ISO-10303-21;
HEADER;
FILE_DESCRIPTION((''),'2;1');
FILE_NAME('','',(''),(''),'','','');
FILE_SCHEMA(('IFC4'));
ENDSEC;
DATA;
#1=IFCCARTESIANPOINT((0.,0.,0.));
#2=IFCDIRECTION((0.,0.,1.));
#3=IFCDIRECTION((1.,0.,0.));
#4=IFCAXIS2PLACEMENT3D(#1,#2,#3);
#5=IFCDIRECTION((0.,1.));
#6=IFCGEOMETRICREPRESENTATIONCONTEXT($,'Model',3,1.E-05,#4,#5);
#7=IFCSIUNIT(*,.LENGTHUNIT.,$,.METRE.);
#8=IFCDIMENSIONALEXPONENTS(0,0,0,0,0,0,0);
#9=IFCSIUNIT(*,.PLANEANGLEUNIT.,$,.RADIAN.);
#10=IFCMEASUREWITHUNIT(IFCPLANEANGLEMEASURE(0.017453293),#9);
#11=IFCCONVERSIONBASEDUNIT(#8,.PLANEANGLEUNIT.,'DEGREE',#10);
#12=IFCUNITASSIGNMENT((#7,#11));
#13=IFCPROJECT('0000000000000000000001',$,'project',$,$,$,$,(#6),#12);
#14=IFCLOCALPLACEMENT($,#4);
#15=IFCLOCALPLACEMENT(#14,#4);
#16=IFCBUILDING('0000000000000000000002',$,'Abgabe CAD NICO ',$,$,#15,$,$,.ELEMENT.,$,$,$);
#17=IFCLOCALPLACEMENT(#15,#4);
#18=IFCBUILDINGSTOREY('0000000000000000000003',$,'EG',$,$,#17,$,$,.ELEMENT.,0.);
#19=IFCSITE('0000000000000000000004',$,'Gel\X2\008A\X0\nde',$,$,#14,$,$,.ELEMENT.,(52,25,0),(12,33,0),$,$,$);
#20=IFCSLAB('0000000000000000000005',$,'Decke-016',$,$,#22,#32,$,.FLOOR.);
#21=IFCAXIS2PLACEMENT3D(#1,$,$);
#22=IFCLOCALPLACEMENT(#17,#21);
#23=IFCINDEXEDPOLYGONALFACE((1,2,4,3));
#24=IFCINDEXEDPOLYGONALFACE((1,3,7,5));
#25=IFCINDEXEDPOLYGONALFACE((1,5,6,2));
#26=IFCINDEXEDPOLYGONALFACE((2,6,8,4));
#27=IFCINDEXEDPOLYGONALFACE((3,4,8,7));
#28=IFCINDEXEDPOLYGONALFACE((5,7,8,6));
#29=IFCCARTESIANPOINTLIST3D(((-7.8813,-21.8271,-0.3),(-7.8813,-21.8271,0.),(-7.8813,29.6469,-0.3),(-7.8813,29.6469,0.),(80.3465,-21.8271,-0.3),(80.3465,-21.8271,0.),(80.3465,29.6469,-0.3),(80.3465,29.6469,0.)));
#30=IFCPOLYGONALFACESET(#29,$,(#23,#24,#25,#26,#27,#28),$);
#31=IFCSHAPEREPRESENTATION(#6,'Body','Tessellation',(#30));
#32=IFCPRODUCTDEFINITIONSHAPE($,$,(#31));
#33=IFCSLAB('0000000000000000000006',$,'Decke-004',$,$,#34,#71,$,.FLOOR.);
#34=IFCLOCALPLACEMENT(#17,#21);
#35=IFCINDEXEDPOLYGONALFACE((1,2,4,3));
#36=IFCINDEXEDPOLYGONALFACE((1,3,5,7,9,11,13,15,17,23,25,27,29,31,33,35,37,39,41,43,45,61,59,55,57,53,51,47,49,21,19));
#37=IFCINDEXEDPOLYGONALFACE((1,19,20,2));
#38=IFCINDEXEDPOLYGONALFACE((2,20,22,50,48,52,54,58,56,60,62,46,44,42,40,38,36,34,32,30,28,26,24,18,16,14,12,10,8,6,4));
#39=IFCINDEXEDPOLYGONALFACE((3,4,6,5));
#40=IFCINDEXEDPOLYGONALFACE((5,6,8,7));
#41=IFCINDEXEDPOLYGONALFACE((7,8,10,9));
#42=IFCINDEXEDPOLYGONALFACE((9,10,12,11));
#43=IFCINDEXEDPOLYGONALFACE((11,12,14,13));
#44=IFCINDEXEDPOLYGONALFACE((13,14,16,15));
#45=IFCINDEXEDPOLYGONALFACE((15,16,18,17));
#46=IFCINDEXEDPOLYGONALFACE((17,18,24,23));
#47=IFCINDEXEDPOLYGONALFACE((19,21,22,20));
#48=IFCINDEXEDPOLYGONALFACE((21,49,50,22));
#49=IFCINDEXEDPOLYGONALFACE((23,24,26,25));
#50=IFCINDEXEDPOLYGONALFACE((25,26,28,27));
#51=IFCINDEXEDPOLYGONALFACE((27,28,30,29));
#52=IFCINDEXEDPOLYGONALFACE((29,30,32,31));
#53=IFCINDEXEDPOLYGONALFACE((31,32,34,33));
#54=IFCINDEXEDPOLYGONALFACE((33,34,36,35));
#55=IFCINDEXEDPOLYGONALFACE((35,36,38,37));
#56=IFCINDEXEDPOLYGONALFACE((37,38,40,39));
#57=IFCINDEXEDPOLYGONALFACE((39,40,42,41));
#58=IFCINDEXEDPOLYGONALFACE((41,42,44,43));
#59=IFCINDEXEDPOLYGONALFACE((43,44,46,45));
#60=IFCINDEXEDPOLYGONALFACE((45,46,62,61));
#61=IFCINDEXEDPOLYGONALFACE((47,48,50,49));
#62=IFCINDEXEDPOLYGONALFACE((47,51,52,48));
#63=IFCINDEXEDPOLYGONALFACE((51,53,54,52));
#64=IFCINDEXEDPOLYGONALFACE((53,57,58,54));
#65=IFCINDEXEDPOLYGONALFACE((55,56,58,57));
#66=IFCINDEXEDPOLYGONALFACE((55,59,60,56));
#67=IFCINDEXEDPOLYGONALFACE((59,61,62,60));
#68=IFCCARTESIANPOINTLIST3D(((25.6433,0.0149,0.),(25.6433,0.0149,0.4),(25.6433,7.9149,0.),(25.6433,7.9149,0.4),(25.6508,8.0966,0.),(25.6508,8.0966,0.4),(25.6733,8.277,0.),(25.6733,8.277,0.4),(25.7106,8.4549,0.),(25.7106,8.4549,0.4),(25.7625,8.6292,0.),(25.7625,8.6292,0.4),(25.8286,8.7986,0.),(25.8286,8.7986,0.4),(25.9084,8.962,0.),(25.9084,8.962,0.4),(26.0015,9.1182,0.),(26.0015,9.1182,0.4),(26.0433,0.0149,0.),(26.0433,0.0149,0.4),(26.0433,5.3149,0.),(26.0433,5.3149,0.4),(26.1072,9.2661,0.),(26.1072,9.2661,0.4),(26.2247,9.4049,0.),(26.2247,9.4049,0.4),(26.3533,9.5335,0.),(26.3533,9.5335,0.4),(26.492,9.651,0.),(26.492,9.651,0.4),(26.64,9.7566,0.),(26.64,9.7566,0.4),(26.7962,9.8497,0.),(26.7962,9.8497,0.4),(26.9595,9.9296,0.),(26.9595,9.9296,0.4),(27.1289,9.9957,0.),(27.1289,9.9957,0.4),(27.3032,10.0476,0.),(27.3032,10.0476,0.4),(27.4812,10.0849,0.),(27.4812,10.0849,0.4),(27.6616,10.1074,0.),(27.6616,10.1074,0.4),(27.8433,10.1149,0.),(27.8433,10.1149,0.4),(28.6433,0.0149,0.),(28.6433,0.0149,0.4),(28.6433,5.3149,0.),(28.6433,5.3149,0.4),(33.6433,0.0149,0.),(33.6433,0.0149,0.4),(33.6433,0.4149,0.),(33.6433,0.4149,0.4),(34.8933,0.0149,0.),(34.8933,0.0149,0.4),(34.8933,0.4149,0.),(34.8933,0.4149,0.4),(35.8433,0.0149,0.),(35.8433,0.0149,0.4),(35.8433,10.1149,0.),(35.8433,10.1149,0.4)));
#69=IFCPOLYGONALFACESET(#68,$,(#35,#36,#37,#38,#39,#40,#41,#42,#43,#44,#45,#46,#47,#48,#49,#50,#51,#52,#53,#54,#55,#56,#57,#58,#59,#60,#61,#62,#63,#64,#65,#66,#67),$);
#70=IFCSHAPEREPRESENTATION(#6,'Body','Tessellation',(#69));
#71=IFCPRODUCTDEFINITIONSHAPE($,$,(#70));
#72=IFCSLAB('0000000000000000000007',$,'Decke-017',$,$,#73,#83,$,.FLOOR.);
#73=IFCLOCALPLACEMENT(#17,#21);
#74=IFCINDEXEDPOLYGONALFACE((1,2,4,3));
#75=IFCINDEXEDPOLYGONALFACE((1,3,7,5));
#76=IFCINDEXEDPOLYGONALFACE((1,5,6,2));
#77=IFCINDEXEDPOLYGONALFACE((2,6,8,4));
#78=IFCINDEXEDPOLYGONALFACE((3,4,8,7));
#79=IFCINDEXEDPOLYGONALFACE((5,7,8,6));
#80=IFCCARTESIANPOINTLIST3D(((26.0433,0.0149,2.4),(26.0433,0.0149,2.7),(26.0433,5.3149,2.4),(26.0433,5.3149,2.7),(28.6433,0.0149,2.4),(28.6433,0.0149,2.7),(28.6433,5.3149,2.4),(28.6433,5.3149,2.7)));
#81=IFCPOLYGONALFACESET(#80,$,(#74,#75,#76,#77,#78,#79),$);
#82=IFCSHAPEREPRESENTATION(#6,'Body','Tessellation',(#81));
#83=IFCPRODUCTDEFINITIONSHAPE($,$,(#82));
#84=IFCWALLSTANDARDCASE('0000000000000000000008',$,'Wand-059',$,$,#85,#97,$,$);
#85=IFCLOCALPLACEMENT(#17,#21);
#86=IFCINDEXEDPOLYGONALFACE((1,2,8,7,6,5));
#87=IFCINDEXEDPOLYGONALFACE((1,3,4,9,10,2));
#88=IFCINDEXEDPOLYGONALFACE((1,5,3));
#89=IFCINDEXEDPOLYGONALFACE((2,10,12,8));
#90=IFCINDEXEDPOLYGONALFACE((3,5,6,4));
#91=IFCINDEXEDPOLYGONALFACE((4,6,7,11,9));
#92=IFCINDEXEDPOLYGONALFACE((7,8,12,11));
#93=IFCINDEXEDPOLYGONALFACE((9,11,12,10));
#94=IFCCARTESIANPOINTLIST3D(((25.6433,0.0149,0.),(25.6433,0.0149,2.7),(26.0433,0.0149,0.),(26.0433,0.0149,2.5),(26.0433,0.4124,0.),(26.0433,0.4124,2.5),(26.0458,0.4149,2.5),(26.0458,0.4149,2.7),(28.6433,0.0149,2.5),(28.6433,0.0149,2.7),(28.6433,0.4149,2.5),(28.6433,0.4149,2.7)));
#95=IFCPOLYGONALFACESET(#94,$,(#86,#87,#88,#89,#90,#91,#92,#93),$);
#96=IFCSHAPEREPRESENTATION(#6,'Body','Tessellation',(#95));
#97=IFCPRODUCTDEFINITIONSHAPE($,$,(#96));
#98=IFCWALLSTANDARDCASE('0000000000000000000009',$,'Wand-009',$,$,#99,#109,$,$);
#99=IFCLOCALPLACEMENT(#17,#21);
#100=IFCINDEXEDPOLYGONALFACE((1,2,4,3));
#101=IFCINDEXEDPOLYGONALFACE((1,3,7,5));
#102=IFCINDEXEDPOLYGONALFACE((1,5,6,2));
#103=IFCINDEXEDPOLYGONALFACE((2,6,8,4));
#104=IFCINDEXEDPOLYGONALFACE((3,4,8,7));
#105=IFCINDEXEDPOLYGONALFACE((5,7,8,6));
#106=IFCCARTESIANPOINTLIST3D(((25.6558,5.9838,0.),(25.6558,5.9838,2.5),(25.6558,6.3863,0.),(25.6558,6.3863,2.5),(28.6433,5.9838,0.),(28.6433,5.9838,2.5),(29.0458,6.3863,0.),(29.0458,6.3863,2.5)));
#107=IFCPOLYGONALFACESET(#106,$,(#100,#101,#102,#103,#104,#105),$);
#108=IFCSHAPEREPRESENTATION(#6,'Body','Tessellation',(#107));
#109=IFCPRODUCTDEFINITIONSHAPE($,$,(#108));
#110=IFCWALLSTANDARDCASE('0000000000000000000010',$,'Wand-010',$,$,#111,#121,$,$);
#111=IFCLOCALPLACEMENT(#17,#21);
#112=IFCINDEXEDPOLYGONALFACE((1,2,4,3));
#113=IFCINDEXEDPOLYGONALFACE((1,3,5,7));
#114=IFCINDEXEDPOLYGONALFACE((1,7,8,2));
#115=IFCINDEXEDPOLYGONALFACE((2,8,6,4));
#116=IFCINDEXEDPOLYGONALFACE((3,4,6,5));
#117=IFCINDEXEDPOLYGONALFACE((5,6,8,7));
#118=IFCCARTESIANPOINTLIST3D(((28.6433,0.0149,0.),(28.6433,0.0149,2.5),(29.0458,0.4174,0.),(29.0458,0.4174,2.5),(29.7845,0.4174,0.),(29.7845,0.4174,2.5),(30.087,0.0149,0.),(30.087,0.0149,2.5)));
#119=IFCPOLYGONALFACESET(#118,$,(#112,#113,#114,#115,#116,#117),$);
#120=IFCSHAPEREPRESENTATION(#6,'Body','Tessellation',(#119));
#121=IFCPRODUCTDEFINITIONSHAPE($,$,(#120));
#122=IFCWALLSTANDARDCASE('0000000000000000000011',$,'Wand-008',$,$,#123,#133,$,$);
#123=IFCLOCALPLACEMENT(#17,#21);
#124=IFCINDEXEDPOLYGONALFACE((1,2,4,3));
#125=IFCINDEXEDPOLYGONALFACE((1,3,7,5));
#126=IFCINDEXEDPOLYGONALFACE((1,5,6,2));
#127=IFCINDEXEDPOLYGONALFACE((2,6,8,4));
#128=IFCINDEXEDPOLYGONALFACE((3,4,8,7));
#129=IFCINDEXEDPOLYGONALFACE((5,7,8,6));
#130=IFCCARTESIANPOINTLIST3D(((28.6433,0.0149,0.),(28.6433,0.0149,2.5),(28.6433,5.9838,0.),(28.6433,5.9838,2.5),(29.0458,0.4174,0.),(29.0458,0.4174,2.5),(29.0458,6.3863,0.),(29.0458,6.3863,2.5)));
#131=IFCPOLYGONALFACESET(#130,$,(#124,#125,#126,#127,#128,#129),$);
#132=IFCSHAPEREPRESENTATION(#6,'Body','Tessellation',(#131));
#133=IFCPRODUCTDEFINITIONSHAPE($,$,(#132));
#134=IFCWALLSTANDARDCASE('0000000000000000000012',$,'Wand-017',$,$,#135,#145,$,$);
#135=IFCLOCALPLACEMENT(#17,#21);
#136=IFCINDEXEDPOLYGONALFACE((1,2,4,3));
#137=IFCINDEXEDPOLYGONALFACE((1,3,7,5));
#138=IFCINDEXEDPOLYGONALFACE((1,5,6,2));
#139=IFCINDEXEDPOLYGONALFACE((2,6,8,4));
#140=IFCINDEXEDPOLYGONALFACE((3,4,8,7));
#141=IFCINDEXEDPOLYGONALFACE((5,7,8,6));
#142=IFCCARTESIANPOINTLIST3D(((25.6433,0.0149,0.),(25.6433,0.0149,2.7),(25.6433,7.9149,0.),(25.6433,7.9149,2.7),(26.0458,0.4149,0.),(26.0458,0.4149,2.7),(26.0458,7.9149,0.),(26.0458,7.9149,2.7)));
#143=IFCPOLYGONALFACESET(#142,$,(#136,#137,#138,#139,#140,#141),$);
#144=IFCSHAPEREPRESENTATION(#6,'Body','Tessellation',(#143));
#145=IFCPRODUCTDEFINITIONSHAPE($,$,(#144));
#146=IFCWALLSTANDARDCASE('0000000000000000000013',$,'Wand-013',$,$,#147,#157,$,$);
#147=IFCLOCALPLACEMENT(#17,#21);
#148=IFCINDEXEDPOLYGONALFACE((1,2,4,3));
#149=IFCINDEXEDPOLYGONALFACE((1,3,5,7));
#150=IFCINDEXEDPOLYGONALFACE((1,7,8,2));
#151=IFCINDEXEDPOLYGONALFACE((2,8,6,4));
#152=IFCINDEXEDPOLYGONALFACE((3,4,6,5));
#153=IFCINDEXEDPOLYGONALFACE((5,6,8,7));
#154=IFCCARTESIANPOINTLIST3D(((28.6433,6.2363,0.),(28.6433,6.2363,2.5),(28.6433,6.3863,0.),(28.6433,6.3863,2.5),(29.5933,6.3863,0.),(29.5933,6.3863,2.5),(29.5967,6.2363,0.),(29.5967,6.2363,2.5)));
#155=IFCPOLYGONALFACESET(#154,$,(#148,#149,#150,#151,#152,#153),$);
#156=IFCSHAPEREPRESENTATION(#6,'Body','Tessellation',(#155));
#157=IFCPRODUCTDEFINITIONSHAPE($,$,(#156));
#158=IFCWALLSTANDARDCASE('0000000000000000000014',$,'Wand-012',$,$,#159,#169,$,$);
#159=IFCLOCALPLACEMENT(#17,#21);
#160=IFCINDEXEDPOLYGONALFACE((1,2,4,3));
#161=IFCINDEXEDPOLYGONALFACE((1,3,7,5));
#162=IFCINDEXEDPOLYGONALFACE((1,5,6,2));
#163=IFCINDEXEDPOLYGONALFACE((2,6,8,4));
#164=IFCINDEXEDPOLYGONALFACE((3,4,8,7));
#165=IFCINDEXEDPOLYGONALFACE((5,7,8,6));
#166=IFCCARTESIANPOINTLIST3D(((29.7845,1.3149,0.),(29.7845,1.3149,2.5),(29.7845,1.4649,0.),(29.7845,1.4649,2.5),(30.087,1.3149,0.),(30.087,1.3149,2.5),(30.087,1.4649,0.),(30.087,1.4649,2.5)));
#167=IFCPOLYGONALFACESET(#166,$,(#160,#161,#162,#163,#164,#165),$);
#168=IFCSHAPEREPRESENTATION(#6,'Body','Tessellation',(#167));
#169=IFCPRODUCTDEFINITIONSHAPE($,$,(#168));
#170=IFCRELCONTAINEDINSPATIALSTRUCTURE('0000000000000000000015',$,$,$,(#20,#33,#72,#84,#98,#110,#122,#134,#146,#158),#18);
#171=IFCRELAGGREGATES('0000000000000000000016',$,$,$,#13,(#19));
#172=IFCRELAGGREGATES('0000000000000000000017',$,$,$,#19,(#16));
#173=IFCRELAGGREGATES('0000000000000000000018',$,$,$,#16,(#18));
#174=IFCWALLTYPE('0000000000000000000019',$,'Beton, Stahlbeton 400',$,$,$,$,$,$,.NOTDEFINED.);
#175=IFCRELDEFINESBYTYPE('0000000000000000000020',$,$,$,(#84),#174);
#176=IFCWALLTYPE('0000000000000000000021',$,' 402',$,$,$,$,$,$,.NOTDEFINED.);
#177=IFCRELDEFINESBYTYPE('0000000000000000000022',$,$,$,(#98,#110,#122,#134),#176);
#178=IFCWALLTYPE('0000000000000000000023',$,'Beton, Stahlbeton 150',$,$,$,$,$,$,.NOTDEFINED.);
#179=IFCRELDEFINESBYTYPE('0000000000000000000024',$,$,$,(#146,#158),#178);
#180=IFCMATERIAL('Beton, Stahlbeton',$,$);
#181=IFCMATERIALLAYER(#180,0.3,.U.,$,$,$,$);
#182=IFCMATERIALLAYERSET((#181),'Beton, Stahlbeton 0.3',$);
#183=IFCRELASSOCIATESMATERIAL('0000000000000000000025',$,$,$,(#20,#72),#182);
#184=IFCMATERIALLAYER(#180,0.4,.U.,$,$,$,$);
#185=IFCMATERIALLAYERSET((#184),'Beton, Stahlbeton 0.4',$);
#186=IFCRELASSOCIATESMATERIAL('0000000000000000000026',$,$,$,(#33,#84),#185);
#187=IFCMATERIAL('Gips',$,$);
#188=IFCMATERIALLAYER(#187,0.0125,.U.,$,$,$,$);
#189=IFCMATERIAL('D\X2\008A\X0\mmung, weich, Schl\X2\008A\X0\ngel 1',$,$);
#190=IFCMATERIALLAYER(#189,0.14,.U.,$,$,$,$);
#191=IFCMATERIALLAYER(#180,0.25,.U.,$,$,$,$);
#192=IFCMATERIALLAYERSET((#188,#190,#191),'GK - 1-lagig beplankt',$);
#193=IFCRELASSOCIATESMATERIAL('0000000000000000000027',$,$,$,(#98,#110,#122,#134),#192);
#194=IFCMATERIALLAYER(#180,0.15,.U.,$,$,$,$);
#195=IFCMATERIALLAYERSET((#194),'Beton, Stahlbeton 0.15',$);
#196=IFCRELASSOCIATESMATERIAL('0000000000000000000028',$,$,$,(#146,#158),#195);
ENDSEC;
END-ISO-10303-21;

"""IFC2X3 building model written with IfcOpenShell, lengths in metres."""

from ifc_helpers import new_model, entity, si_unit, converted_unit, point, direction, frame, frame_2d, origin_with_axes, origin_2d_with_axis, place, context, project, spatial, polyline, circle_curve, parameter, trimmed, segment, composite_curve, rectangle, outline, extrude, material, layer, layer_set, layer_usage, type_object, element, save


model = new_model("IFC2X3")

# Units and contexts
model_context = context("Model", 3, precision=1e-05, world=origin_with_axes(), true_north=direction((0.0, 1.0)))
ifc_project = project(units=[si_unit("LENGTHUNIT", "METRE"), converted_unit("PLANEANGLEUNIT", "DEGREE", entity("IfcPlaneAngleMeasure", 0.017453293), si_unit("PLANEANGLEUNIT", "RADIAN"), dimensions=[0, 0, 0, 0, 0, 0, 0])], contexts=[model_context])

# Site, building, storey
site_placement = place(None, origin_with_axes())
site = spatial("IfcSite", under=ifc_project, at=site_placement, Name="Gel\u008ande", CompositionType="ELEMENT", RefLatitude=(52, 25, 0), RefLongitude=(12, 33, 0))
building_placement = place(site_placement, origin_with_axes())
building = spatial("IfcBuilding", under=site, at=building_placement, Name="Abgabe CAD NICO ", CompositionType="ELEMENT")
storey_placement = place(building_placement, origin_with_axes())
storey = spatial("IfcBuildingStorey", under=building, at=storey_placement, Name="EG", CompositionType="ELEMENT", Elevation=0.0)

# Slab
ifc_material_1 = material(Name="Beton, Stahlbeton")
ifc_layer_1 = layer(ifc_material_1, 0.3, ventilated="UNKNOWN")
ifc_layer_set_1 = layer_set([ifc_layer_1], Name="Beton, Stahlbeton 0.3")
ifc_layer_usage_1 = layer_usage(ifc_layer_set_1, "AXIS3", "NEGATIVE", 0.3)
slab_1_placement = place(storey_placement, frame((-7.8813, 29.6469, -0.3), z_axis=(0.0, 0.0, 1.0), x_axis=(1.0, 0.0, 0.0)))
element("IfcSlab", 1, at=slab_1_placement, inside=storey, material=ifc_layer_usage_1, Name="Decke-016", PredefinedType="FLOOR", context=model_context, shape_type="SweptSolid", body=[
    extrude(outline(polyline([(0.0, 0.0), (0.0, -51.474), (88.2278, -51.474), (88.2278, 0.0), (0.0, 0.0)])), origin_with_axes(), (0.0, 0.0, 1.0), 0.3),
])

# Slabs
ifc_layer_2 = layer(ifc_material_1, 0.4, ventilated="UNKNOWN")
ifc_layer_set_2 = layer_set([ifc_layer_2], Name="Beton, Stahlbeton 0.4")
ifc_layer_usage_2 = layer_usage(ifc_layer_set_2, "AXIS3", "NEGATIVE", 0.4)
slab_2_placement = place(storey_placement, frame((27.8433, 10.1149, 0.0), z_axis=(0.0, 0.0, 1.0), x_axis=(1.0, 0.0, 0.0)))
element("IfcSlab", 2, at=slab_2_placement, inside=storey, material=ifc_layer_usage_2, Name="Decke-004", PredefinedType="FLOOR", context=model_context, shape_type="SweptSolid", body=[
    extrude(outline(composite_curve([segment(polyline([(-2.2, -2.2), (-2.2, -10.1), (-1.8, -10.1), (-1.8, -4.8), (0.8, -4.8), (0.8, -10.1), (5.8, -10.1), (5.8, -9.7), (7.05, -9.7), (7.05, -10.1), (8.0, -10.1), (8.0, 0.0), (0.0, 0.0)]), True, "CONTINUOUS"), segment(trimmed(circle_curve(frame_2d((0.0, -2.2), x_axis=(0.0, 1.0)), 2.2), [point((0.0, 0.0)), parameter(0.0)], [point((-2.2, -2.2)), parameter(90.0)], True, "CARTESIAN"), True, "CONTINUOUS")], self_intersect=False)), origin_with_axes(), (0.0, 0.0, 1.0), 0.4),
])
ifc_layer_usage_3 = layer_usage(ifc_layer_set_1, "AXIS3", "NEGATIVE", 0.3)
slab_3_placement = place(storey_placement, frame((26.0433, 0.0149, 2.4), z_axis=(0.0, 0.0, 1.0), x_axis=(1.0, 0.0, 0.0)))
element("IfcSlab", 3, at=slab_3_placement, inside=storey, material=ifc_layer_usage_3, Name="Decke-017", PredefinedType="FLOOR", context=model_context, shape_type="SweptSolid", body=[
    extrude(outline(polyline([(0.0, 0.0), (2.6, 0.0), (2.6, 5.3), (0.0, 5.3), (0.0, 0.0)])), origin_with_axes(), (0.0, 0.0, 1.0), 0.3),
])

# Wall, opening
ifc_layer_usage_4 = layer_usage(ifc_layer_set_2, "AXIS2", "NEGATIVE", 0.0)
wall_type_1 = type_object("IfcWallType", Name="Beton, Stahlbeton 400", PredefinedType="NOTDEFINED")
wall_1_placement = place(storey_placement, frame((28.6433, 0.0149, 0.0), z_axis=(0.0, 0.0, 1.0), x_axis=(-1.0, 0.0, 0.0)))
wall_1 = element("IfcWallStandardCase", 4, at=wall_1_placement, inside=storey, type_object=wall_type_1, material=ifc_layer_usage_4, Name="Wand-059", context=model_context, shape_type="SweptSolid", body=[
    extrude(outline(polyline([(0.0, -0.4), (2.5975, -0.4), (3.0, 0.0), (0.0, 0.0), (0.0, -0.4)])), origin_with_axes(), (0.0, 0.0, 1.0), 2.7),
])
opening_1_placement = place(wall_1_placement, frame((1.3, 0.0, 0.0), z_axis=(0.0, 0.0, 1.0), x_axis=(1.0, 0.0, 0.0)))
element("IfcOpeningElement", 5, at=opening_1_placement, cuts=wall_1, context=model_context, shape_type="SweptSolid", body=[
    extrude(rectangle(XDim=2.6, YDim=2.5, at=origin_2d_with_axis()), frame((0.0, -0.401, 1.25), z_axis=(0.0, 1.0, 0.0), x_axis=(1.0, 0.0, 0.0)), (0.0, 0.0, 1.0), 1.202),
])

# Walls
ifc_material_2 = material(Name="Gips")
ifc_layer_3 = layer(ifc_material_2, 0.0125, ventilated="UNKNOWN")
ifc_material_3 = material(Name="D\u008ammung, weich, Schl\u008angel 1")
ifc_layer_4 = layer(ifc_material_3, 0.14, ventilated="UNKNOWN")
ifc_layer_5 = layer(ifc_material_1, 0.25, ventilated="UNKNOWN")
ifc_layer_set_3 = layer_set([ifc_layer_3, ifc_layer_4, ifc_layer_5], Name="GK - 1-lagig beplankt")
ifc_layer_usage_5 = layer_usage(ifc_layer_set_3, "AXIS2", "POSITIVE", 0.0)
wall_type_2 = type_object("IfcWallType", Name=" 402", PredefinedType="NOTDEFINED")
wall_2_placement = place(storey_placement, frame((25.6558, 5.9838, 0.0), z_axis=(0.0, 0.0, 1.0), x_axis=(1.0, 0.0, 0.0)))
element("IfcWallStandardCase", 6, at=wall_2_placement, inside=storey, type_object=wall_type_2, material=ifc_layer_usage_5, Name="Wand-009", context=model_context, shape_type="SweptSolid", body=[
    extrude(outline(polyline([(0.0, 0.0), (2.9875, 0.0), (3.39, 0.4025), (0.0, 0.4025), (0.0, 0.0)])), origin_with_axes(), (0.0, 0.0, 1.0), 2.5),
])
ifc_layer_usage_6 = layer_usage(ifc_layer_set_3, "AXIS2", "NEGATIVE", 0.0)
wall_3_placement = place(storey_placement, frame((30.087, 0.0149, 0.0), z_axis=(0.0, 0.0, 1.0), x_axis=(-1.0, 0.0, 0.0)))
element("IfcWallStandardCase", 7, at=wall_3_placement, inside=storey, type_object=wall_type_2, material=ifc_layer_usage_6, Name="Wand-010", context=model_context, shape_type="SweptSolid", body=[
    extrude(outline(polyline([(0.3025, -0.4025), (1.0413, -0.4025), (1.4438, 0.0), (0.0, 0.0), (0.3025, -0.4025)])), origin_with_axes(), (0.0, 0.0, 1.0), 2.5),
])
ifc_layer_usage_7 = layer_usage(ifc_layer_set_3, "AXIS2", "NEGATIVE", 0.0)
wall_4_placement = place(storey_placement, frame((28.6433, 0.0149, 0.0), z_axis=(0.0, 0.0, 1.0), x_axis=(0.0, 1.0, 0.0)))
element("IfcWallStandardCase", 8, at=wall_4_placement, inside=storey, type_object=wall_type_2, material=ifc_layer_usage_7, Name="Wand-008", context=model_context, shape_type="SweptSolid", body=[
    extrude(outline(polyline([(0.4025, -0.4025), (6.3714, -0.4025), (5.9689, 0.0), (0.0, 0.0), (0.4025, -0.4025)])), origin_with_axes(), (0.0, 0.0, 1.0), 2.5),
])
ifc_layer_usage_8 = layer_usage(ifc_layer_set_3, "AXIS2", "NEGATIVE", 0.0)
wall_5_placement = place(storey_placement, frame((25.6433, 0.0149, 0.0), z_axis=(0.0, 0.0, 1.0), x_axis=(0.0, 1.0, 0.0)))
element("IfcWallStandardCase", 9, at=wall_5_placement, inside=storey, type_object=wall_type_2, material=ifc_layer_usage_8, Name="Wand-017", context=model_context, shape_type="SweptSolid", body=[
    extrude(outline(polyline([(0.4, -0.4025), (7.9, -0.4025), (7.9, 0.0), (0.0, 0.0), (0.4, -0.4025)])), origin_with_axes(), (0.0, 0.0, 1.0), 2.7),
])

# Shared definitions
ifc_layer_6 = layer(ifc_material_1, 0.15, ventilated="UNKNOWN")
ifc_layer_set_4 = layer_set([ifc_layer_6], Name="Beton, Stahlbeton 0.15")
wall_type_3 = type_object("IfcWallType", Name="Beton, Stahlbeton 150", PredefinedType="NOTDEFINED")

# Walls
ifc_layer_usage_9 = layer_usage(ifc_layer_set_4, "AXIS2", "NEGATIVE", 0.0)
wall_6_placement = place(storey_placement, frame((28.6433, 6.3863, 0.0), z_axis=(0.0, 0.0, 1.0), x_axis=(1.0, 0.0, 0.0)))
element("IfcWallStandardCase", 10, at=wall_6_placement, inside=storey, type_object=wall_type_3, material=ifc_layer_usage_9, Name="Wand-013", context=model_context, shape_type="SweptSolid", body=[
    extrude(outline(polyline([(0.0, -0.15), (0.9534, -0.15), (0.95, 0.0), (0.0, 0.0), (0.0, -0.15)])), origin_with_axes(), (0.0, 0.0, 1.0), 2.5),
])
ifc_layer_usage_10 = layer_usage(ifc_layer_set_4, "AXIS2", "NEGATIVE", 0.0)
wall_7_placement = place(storey_placement, frame((30.087, 1.3149, 0.0), z_axis=(0.0, 0.0, 1.0), x_axis=(-1.0, 0.0, 0.0)))
element("IfcWallStandardCase", 11, at=wall_7_placement, inside=storey, type_object=wall_type_3, material=ifc_layer_usage_10, Name="Wand-012", context=model_context, shape_type="SweptSolid", body=[
    extrude(outline(polyline([(0.0, -0.15), (0.3025, -0.15), (0.3025, 0.0), (0.0, 0.0), (0.0, -0.15)])), origin_with_axes(), (0.0, 0.0, 1.0), 2.5),
])

save(model, "model.ifc")
